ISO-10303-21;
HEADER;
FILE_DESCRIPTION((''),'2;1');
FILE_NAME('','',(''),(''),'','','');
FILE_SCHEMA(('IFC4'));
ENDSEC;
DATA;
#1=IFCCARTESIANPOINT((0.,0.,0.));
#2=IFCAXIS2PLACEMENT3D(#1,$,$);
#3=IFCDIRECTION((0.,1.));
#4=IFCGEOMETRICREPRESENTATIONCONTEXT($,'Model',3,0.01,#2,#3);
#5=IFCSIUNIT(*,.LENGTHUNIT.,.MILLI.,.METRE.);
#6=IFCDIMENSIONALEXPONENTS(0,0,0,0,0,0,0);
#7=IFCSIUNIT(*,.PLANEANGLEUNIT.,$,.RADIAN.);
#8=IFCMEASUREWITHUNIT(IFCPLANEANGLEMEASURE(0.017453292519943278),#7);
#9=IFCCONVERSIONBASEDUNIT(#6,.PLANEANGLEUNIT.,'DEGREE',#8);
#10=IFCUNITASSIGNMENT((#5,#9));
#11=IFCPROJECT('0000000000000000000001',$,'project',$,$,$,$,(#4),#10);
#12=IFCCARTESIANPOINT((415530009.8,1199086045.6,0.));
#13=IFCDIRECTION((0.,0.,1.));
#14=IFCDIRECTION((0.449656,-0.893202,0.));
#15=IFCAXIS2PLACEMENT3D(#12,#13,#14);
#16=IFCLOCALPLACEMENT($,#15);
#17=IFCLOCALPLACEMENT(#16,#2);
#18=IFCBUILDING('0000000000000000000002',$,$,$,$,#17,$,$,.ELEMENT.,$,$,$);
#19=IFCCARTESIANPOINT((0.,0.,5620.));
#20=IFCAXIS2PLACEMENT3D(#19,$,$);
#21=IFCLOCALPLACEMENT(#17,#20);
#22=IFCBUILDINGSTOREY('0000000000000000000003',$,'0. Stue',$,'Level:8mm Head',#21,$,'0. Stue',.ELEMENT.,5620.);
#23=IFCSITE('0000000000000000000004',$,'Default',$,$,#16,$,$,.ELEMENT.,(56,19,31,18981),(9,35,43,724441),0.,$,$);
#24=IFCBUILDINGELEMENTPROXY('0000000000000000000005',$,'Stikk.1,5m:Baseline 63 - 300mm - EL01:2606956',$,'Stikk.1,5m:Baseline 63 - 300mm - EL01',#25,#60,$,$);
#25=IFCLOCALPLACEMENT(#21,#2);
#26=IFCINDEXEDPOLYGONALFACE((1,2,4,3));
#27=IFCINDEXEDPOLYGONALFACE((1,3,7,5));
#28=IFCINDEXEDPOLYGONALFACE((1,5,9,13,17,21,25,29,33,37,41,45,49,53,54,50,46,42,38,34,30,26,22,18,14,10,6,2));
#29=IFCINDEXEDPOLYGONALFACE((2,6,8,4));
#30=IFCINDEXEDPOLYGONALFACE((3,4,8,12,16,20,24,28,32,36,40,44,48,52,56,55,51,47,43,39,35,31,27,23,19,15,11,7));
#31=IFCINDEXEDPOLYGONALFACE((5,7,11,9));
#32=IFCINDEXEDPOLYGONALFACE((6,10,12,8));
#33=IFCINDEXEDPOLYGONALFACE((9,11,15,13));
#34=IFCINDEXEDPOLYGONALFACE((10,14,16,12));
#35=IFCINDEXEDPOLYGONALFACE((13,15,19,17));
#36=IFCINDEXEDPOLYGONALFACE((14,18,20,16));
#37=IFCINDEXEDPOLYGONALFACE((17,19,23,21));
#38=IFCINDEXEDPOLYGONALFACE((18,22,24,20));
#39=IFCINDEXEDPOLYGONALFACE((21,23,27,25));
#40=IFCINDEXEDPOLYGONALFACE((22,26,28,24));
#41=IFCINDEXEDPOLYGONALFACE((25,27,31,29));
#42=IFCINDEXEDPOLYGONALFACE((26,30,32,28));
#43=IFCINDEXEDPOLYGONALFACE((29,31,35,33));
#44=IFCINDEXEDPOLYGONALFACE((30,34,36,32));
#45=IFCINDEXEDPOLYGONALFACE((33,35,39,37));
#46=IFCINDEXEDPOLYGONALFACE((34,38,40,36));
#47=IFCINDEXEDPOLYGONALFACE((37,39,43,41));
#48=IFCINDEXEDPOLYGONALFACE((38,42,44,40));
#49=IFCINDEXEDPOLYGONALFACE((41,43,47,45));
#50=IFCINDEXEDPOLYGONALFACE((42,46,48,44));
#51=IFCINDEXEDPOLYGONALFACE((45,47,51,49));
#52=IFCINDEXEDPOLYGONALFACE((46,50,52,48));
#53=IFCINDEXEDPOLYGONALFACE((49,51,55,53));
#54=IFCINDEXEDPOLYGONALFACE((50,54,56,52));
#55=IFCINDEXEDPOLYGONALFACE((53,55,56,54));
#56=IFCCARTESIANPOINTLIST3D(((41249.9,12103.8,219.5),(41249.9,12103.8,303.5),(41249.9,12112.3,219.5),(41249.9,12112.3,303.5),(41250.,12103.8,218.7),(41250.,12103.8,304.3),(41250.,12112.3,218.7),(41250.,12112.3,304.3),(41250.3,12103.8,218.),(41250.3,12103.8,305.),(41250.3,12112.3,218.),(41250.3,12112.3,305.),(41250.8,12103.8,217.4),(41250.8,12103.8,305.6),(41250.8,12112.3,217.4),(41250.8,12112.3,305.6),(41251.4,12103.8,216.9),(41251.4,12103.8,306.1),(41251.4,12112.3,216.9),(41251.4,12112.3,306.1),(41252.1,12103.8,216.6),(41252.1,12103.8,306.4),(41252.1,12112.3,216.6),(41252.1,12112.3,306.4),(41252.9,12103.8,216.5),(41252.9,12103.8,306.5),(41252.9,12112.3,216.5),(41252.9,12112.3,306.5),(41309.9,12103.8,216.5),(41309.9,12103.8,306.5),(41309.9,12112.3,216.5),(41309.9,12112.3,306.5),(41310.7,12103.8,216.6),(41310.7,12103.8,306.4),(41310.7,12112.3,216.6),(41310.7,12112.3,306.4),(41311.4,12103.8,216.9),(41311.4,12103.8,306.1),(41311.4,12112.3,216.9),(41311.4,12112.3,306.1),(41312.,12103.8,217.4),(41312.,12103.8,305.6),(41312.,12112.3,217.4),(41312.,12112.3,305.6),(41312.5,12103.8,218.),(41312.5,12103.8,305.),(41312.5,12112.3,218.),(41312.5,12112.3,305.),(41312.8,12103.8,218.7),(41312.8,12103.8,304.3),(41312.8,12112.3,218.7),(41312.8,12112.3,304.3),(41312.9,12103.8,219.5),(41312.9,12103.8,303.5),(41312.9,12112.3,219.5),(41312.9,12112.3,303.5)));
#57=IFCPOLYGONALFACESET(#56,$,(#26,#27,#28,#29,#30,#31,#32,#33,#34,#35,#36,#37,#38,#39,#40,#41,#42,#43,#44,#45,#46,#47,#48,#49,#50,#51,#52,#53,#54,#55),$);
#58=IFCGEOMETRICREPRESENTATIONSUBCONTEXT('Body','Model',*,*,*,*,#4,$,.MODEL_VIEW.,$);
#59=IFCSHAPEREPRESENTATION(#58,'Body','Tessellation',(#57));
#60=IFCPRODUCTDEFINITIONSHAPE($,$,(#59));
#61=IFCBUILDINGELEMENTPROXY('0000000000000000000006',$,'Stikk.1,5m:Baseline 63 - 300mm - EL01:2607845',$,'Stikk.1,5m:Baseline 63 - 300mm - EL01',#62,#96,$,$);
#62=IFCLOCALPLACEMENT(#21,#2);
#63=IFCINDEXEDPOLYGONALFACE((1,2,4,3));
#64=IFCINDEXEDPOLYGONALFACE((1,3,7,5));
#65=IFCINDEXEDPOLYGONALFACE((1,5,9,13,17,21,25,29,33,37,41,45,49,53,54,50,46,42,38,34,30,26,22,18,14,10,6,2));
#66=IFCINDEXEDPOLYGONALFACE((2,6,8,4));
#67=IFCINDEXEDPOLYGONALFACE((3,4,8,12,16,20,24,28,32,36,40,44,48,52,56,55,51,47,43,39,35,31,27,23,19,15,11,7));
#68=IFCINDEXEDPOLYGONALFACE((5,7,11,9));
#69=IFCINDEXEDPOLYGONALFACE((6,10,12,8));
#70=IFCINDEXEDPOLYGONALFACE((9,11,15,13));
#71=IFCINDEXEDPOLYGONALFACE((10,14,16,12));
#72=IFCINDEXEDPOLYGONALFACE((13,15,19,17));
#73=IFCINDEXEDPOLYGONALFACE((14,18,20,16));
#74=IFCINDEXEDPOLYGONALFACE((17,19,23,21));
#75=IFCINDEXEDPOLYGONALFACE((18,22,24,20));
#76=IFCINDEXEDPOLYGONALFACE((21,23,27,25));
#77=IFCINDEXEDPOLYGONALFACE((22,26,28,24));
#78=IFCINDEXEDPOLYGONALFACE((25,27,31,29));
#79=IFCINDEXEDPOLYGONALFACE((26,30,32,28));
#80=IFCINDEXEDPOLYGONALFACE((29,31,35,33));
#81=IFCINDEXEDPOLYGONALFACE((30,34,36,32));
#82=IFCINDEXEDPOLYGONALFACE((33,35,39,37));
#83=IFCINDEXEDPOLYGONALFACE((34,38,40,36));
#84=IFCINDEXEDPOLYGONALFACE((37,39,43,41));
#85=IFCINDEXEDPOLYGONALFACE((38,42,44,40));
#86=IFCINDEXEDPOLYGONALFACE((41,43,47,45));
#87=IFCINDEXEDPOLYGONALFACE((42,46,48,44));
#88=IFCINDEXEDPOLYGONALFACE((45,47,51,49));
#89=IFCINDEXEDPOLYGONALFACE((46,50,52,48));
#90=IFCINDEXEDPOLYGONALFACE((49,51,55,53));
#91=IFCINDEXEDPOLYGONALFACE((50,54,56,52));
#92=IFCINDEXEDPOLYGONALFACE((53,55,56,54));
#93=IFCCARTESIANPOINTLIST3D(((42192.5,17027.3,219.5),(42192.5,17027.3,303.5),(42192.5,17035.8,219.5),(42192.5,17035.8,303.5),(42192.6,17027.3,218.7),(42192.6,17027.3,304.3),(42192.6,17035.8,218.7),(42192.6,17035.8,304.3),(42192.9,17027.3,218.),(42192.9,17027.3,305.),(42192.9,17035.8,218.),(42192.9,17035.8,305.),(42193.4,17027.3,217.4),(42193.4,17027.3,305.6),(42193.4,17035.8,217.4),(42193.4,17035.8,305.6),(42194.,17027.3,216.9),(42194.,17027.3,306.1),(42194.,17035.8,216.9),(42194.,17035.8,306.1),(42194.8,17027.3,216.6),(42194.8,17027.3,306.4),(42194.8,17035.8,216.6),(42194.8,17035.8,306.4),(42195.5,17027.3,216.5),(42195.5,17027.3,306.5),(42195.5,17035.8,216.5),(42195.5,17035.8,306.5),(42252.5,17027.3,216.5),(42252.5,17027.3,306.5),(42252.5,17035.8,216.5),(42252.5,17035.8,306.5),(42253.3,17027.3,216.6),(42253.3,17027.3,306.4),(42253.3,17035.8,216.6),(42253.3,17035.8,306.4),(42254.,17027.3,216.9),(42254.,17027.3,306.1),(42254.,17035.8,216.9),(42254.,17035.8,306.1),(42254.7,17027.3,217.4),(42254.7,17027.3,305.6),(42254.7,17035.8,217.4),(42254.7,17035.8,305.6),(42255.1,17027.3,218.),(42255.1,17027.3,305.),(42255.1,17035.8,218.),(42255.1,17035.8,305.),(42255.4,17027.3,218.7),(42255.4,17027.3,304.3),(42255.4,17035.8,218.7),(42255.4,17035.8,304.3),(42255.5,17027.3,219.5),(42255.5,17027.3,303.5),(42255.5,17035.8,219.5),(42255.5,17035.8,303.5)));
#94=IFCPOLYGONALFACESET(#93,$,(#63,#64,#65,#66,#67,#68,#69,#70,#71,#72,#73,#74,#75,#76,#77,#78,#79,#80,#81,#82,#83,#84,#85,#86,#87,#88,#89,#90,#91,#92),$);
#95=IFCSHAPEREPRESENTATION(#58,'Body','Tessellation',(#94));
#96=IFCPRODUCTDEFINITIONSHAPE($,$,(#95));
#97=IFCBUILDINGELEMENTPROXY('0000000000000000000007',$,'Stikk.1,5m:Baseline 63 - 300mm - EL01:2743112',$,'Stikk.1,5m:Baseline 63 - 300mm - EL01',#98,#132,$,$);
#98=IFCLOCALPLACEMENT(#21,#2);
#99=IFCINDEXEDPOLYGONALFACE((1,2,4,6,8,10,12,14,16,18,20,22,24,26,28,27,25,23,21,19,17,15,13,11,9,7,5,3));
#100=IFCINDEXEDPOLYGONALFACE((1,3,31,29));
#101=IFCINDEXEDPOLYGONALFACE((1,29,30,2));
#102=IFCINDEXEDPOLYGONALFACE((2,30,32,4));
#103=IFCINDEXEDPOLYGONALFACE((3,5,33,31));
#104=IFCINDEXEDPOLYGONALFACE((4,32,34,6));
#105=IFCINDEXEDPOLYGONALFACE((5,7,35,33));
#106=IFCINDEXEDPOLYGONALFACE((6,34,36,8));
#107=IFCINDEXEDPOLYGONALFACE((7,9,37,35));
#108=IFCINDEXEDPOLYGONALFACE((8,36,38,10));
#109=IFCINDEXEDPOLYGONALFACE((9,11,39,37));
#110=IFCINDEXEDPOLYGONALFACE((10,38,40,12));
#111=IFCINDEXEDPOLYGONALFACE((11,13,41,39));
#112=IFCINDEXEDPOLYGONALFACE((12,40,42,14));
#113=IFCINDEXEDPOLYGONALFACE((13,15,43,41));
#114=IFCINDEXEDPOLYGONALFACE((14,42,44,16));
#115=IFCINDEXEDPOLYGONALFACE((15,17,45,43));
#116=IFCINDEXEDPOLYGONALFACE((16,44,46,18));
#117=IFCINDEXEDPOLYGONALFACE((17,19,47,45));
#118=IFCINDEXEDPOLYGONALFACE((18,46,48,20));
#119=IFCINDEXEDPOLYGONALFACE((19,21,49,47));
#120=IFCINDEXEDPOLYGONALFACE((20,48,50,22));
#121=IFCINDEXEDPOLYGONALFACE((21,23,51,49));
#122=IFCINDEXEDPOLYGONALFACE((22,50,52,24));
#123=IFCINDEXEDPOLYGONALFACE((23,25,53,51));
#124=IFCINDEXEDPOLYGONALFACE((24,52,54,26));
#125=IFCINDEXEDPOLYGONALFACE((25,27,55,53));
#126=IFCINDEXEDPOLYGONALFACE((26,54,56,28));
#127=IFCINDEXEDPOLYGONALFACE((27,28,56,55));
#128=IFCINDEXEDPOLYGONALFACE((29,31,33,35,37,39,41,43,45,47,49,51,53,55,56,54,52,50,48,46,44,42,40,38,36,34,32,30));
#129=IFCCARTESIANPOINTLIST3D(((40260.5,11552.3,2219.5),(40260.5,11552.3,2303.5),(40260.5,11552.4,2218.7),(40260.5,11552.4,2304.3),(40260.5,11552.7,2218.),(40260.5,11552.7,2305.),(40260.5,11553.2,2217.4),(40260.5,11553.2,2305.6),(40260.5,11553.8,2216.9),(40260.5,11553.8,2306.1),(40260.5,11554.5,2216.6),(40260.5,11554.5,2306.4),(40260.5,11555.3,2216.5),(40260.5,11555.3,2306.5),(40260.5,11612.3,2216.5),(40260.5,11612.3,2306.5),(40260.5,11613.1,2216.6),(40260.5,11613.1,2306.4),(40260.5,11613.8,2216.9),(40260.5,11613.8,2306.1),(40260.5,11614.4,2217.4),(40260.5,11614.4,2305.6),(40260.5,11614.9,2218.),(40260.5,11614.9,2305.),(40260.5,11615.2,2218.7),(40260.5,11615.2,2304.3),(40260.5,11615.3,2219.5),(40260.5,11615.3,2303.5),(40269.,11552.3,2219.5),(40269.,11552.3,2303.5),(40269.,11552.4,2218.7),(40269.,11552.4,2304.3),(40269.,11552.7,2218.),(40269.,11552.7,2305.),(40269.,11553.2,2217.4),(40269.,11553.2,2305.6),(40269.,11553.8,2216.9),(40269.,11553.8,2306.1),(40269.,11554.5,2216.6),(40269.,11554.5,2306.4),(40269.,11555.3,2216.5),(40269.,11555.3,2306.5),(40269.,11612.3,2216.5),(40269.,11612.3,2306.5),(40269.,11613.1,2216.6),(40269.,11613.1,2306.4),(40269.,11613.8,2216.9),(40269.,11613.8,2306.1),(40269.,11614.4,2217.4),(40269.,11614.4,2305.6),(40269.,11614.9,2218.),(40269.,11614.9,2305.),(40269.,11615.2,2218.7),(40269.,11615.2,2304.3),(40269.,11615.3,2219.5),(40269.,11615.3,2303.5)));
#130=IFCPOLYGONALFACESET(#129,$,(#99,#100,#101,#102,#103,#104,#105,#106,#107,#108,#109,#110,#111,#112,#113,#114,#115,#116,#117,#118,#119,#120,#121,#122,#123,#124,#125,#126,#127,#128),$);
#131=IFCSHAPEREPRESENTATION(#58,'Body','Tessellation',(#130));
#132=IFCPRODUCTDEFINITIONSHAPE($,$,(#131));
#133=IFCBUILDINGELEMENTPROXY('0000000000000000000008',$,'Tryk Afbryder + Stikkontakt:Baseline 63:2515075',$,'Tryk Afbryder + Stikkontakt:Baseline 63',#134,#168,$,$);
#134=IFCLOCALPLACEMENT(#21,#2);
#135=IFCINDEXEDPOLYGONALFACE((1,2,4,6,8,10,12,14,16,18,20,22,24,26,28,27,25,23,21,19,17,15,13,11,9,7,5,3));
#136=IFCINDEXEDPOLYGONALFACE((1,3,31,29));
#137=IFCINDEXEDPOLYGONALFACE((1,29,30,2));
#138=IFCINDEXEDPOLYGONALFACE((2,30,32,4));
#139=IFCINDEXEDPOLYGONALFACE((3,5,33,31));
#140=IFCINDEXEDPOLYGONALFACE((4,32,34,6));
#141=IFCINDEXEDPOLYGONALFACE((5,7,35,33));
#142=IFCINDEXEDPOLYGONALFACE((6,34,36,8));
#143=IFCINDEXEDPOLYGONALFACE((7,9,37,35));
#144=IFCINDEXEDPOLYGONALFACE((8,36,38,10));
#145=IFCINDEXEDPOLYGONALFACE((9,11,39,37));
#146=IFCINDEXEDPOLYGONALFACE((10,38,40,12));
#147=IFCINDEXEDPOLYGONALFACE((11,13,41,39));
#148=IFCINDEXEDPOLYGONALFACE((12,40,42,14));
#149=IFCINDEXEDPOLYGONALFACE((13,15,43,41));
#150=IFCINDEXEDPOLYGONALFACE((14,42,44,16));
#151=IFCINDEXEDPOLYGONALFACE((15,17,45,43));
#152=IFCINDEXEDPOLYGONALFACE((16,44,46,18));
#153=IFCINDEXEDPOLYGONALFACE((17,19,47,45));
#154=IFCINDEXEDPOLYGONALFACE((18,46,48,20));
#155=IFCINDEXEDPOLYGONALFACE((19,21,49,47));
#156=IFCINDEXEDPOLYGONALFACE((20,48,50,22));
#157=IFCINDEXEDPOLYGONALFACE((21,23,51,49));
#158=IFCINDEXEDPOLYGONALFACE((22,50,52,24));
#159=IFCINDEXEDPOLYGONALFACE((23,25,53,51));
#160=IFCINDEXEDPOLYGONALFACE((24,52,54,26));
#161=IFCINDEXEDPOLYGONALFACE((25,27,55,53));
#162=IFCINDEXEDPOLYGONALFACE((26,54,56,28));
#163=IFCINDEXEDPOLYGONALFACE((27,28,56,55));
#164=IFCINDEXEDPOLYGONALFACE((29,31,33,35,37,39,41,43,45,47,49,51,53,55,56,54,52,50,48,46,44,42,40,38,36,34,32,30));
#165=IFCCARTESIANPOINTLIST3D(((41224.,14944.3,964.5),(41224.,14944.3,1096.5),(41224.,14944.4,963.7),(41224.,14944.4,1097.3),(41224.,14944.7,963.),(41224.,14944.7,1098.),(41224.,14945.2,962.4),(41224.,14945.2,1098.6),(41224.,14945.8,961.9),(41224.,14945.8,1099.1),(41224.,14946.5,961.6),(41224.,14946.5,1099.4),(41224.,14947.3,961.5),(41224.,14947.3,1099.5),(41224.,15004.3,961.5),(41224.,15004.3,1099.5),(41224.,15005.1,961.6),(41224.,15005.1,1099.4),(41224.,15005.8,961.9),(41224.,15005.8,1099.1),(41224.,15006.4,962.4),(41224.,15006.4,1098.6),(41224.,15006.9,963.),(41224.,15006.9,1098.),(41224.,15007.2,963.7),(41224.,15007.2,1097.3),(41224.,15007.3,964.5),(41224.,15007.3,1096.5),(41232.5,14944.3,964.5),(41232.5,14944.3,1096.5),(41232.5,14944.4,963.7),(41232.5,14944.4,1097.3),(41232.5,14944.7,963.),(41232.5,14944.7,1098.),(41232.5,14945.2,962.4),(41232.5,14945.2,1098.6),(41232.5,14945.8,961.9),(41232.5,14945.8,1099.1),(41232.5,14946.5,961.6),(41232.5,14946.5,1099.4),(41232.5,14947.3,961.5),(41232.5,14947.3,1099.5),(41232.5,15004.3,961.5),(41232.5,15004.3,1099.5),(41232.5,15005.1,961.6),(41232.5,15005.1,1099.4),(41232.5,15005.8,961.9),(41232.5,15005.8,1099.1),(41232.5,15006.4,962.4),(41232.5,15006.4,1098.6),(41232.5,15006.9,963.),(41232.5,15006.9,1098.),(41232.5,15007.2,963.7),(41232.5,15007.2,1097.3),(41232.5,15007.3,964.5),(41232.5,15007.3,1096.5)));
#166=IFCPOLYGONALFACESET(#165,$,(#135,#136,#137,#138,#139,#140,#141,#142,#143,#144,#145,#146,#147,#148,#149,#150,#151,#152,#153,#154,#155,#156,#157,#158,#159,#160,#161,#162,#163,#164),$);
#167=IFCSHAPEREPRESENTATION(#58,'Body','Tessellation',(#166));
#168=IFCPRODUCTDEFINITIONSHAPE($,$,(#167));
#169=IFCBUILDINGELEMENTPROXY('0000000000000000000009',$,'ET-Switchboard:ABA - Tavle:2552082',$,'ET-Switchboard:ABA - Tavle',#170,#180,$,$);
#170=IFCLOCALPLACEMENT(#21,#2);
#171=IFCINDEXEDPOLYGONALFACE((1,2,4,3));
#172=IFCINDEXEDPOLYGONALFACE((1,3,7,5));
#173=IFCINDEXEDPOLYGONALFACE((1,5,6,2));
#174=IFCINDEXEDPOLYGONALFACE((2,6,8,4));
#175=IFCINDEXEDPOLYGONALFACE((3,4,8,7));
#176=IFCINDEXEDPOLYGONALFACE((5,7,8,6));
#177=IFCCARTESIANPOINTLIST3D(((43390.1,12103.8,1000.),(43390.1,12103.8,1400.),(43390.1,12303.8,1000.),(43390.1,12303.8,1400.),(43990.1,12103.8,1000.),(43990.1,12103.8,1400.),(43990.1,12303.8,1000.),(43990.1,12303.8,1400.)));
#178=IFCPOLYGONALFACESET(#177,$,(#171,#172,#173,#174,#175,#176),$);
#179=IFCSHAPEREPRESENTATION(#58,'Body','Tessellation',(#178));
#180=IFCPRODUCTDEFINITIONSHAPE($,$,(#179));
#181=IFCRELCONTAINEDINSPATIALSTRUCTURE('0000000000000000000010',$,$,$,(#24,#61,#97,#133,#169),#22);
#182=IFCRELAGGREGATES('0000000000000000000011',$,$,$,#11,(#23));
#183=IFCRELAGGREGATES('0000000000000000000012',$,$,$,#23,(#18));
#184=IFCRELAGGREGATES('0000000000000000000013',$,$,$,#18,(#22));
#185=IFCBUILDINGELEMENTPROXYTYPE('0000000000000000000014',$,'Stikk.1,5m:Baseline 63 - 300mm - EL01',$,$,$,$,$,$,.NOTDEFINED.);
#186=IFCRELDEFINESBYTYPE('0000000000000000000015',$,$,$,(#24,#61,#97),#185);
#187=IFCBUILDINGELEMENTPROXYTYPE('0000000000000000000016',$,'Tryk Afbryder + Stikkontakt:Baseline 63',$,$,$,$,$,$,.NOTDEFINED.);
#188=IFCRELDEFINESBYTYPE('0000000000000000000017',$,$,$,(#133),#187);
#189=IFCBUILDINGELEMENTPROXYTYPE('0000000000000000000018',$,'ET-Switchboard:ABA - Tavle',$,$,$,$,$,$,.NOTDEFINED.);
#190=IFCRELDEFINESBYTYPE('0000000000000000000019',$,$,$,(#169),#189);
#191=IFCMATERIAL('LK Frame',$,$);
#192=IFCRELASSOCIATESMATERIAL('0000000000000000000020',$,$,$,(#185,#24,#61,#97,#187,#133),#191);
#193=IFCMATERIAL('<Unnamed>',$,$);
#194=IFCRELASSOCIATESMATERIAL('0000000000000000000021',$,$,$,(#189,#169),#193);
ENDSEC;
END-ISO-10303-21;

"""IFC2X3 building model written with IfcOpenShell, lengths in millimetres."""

from ifc_helpers import new_model, entity, si_unit, converted_unit, direction, frame, frame_2d, origin, origin_2d_with_axis, place, context, subcontext, project, spatial, polyline, circle_curve, parameter, trimmed, segment, composite_curve, rectangle, outline, extrude, source, transform, mapped, material, type_object, type_shapes, element, save


model = new_model("IFC2X3")

# Units and contexts
model_context = context("Model", 3, precision=0.01, world=origin(), true_north=direction((0.0, 1.0)))
body_context = subcontext(model_context, "Body", "Model", "MODEL_VIEW")
ifc_project = project(units=[si_unit("LENGTHUNIT", "METRE", prefix="MILLI"), converted_unit("PLANEANGLEUNIT", "DEGREE", entity("IfcPlaneAngleMeasure", 0.017453292519943278), si_unit("PLANEANGLEUNIT", "RADIAN"), dimensions=[0, 0, 0, 0, 0, 0, 0])], contexts=[model_context])

# Site, building, storey
site_placement = place(None, frame((415530009.8, 1199086045.6, 0.0), z_axis=(0.0, 0.0, 1.0), x_axis=(0.449656, -0.893202, 0.0)))
site = spatial("IfcSite", under=ifc_project, at=site_placement, Name="Default", CompositionType="ELEMENT", RefLatitude=(56, 19, 31, 18981), RefLongitude=(9, 35, 43, 724441), RefElevation=0.0)
building_placement = place(site_placement, origin())
building = spatial("IfcBuilding", under=site, at=building_placement, CompositionType="ELEMENT")
storey_placement = place(building_placement, frame((0.0, 0.0, 5620.0)))
storey = spatial("IfcBuildingStorey", under=building, at=storey_placement, Name="0. Stue", ObjectType="Level:8mm Head", LongName="0. Stue", CompositionType="ELEMENT", Elevation=5620.0)

# Building element proxies
ifc_material_1 = material(Name="LK Frame")
building_element_proxy_type_1 = type_object("IfcBuildingElementProxyType", Name="Stikk.1,5m:Baseline 63 - 300mm - EL01", PredefinedType="NOTDEFINED", material=ifc_material_1)
shared_shape_1 = source(origin(), body_context, "Body", "SweptSolid", [
    extrude(outline(composite_curve([segment(polyline([(-42.0, -31.5), (42.0, -31.5)]), True, "CONTINUOUS"), segment(trimmed(circle_curve(frame_2d((42.0, -28.5), x_axis=(-1.0, 0.0)), 3.0), [parameter(90.0)], [parameter(180.0)], True, "PARAMETER"), True, "CONTINUOUS"), segment(polyline([(45.0, -28.5), (45.0, 28.5)]), True, "CONTINUOUS"), segment(trimmed(circle_curve(frame_2d((42.0, 28.5), x_axis=(-1.0, 0.0)), 3.0), [parameter(180.0)], [parameter(270.0)], True, "PARAMETER"), True, "CONTINUOUS"), segment(polyline([(42.0, 31.5), (-42.0, 31.5)]), True, "CONTINUOUS"), segment(trimmed(circle_curve(frame_2d((-42.0, 28.5), x_axis=(1.0, 0.0)), 3.0), [parameter(90.0)], [parameter(180.0)], True, "PARAMETER"), True, "CONTINUOUS"), segment(polyline([(-45.0, 28.5), (-45.0, -28.5)]), True, "CONTINUOUS"), segment(trimmed(circle_curve(frame_2d((-42.0, -28.5), x_axis=(1.0, 0.0)), 3.0), [parameter(180.0)], [parameter(270.0)], True, "PARAMETER"), True, "CONTINUOUS")], self_intersect=False)), frame((0.0, -38.5, 0.0), z_axis=(0.0, 0.0, 1.0), x_axis=(0.0, 1.0, 0.0)), (0.0, 0.0, 1.0), 8.5),
])
type_shapes(building_element_proxy_type_1, [shared_shape_1])
for number, where, z_axis, x_axis, name in (
    (1, (41281.4, 12103.8, 300.0), (0.0, 1.0, 0.0), (-1.0, 0.0, 0.0), "Stikk.1,5m:Baseline 63 - 300mm - EL01:2606956"),
    (2, (42224.0, 17035.8, 300.0), (0.0, -1.0, 0.0), (1.0, 0.0, 0.0), "Stikk.1,5m:Baseline 63 - 300mm - EL01:2607845"),
    (3, (40260.5, 11583.8, 2300.0), (1.0, 0.0, 0.0), (0.0, 1.0, 0.0), "Stikk.1,5m:Baseline 63 - 300mm - EL01:2743112"),
):
    element("IfcBuildingElementProxy", number, at=place(storey_placement, frame(where, z_axis=z_axis, x_axis=x_axis)), inside=storey, type_object=building_element_proxy_type_1, material=ifc_material_1, Name=name, ObjectType="Stikk.1,5m:Baseline 63 - 300mm - EL01", context=body_context, shape_type="MappedRepresentation", body=[
        mapped(shared_shape_1, transform((0.0, 0.0, 0.0), scale=1.0)),
    ])
building_element_proxy_type_2 = type_object("IfcBuildingElementProxyType", Name="Tryk Afbryder + Stikkontakt:Baseline 63", PredefinedType="NOTDEFINED", material=ifc_material_1)
shared_shape_2 = source(origin(), body_context, "Body", "SweptSolid", [
    extrude(outline(composite_curve([segment(polyline([(-66.0, -31.5), (66.0, -31.5)]), True, "CONTINUOUS"), segment(trimmed(circle_curve(frame_2d((66.0, -28.5), x_axis=(-1.0, 0.0)), 3.0), [parameter(90.0)], [parameter(180.0)], True, "PARAMETER"), True, "CONTINUOUS"), segment(polyline([(69.0, -28.5), (69.0, 28.5)]), True, "CONTINUOUS"), segment(trimmed(circle_curve(frame_2d((66.0, 28.5), x_axis=(-1.0, 0.0)), 3.0), [parameter(180.0)], [parameter(270.0)], True, "PARAMETER"), True, "CONTINUOUS"), segment(polyline([(66.0, 31.5), (-66.0, 31.5)]), True, "CONTINUOUS"), segment(trimmed(circle_curve(frame_2d((-66.0, 28.5), x_axis=(1.0, 0.0)), 3.0), [parameter(90.0)], [parameter(180.0)], True, "PARAMETER"), True, "CONTINUOUS"), segment(polyline([(-69.0, 28.5), (-69.0, -28.5)]), True, "CONTINUOUS"), segment(trimmed(circle_curve(frame_2d((-66.0, -28.5), x_axis=(1.0, 0.0)), 3.0), [parameter(180.0)], [parameter(270.0)], True, "PARAMETER"), True, "CONTINUOUS")], self_intersect=False)), frame((0.0, -69.5, 0.0), z_axis=(0.0, 0.0, 1.0), x_axis=(0.0, 1.0, 0.0)), (0.0, 0.0, 1.0), 8.5),
])
type_shapes(building_element_proxy_type_2, [shared_shape_2])
proxy_1_placement = place(storey_placement, frame((41224.0, 14975.8, 1100.0), z_axis=(1.0, 0.0, 0.0), x_axis=(0.0, 1.0, 0.0)))
element("IfcBuildingElementProxy", 4, at=proxy_1_placement, inside=storey, type_object=building_element_proxy_type_2, material=ifc_material_1, Name="Tryk Afbryder + Stikkontakt:Baseline 63:2515075", ObjectType="Tryk Afbryder + Stikkontakt:Baseline 63", context=body_context, shape_type="MappedRepresentation", body=[
    mapped(shared_shape_2, transform((0.0, 0.0, 0.0), scale=1.0)),
])
ifc_material_2 = material(Name="<Unnamed>")
building_element_proxy_type_3 = type_object("IfcBuildingElementProxyType", Name="ET-Switchboard:ABA - Tavle", PredefinedType="NOTDEFINED", material=ifc_material_2)
shared_shape_3 = source(origin(), body_context, "Body", "SweptSolid", [
    extrude(rectangle(XDim=200.0, YDim=600.0, at=origin_2d_with_axis()), frame((0.0, 100.0, 0.0), z_axis=(0.0, 0.0, 1.0), x_axis=(0.0, 1.0, 0.0)), (0.0, 0.0, 1.0), 400.0),
])
type_shapes(building_element_proxy_type_3, [shared_shape_3])
proxy_2_placement = place(storey_placement, frame((43690.1, 12103.8, 1000.0)))
element("IfcBuildingElementProxy", 5, at=proxy_2_placement, inside=storey, type_object=building_element_proxy_type_3, material=ifc_material_2, Name="ET-Switchboard:ABA - Tavle:2552082", ObjectType="ET-Switchboard:ABA - Tavle", context=body_context, shape_type="MappedRepresentation", body=[
    mapped(shared_shape_3, transform((0.0, 0.0, 0.0), scale=1.0)),
])

save(model, "model.ifc")
